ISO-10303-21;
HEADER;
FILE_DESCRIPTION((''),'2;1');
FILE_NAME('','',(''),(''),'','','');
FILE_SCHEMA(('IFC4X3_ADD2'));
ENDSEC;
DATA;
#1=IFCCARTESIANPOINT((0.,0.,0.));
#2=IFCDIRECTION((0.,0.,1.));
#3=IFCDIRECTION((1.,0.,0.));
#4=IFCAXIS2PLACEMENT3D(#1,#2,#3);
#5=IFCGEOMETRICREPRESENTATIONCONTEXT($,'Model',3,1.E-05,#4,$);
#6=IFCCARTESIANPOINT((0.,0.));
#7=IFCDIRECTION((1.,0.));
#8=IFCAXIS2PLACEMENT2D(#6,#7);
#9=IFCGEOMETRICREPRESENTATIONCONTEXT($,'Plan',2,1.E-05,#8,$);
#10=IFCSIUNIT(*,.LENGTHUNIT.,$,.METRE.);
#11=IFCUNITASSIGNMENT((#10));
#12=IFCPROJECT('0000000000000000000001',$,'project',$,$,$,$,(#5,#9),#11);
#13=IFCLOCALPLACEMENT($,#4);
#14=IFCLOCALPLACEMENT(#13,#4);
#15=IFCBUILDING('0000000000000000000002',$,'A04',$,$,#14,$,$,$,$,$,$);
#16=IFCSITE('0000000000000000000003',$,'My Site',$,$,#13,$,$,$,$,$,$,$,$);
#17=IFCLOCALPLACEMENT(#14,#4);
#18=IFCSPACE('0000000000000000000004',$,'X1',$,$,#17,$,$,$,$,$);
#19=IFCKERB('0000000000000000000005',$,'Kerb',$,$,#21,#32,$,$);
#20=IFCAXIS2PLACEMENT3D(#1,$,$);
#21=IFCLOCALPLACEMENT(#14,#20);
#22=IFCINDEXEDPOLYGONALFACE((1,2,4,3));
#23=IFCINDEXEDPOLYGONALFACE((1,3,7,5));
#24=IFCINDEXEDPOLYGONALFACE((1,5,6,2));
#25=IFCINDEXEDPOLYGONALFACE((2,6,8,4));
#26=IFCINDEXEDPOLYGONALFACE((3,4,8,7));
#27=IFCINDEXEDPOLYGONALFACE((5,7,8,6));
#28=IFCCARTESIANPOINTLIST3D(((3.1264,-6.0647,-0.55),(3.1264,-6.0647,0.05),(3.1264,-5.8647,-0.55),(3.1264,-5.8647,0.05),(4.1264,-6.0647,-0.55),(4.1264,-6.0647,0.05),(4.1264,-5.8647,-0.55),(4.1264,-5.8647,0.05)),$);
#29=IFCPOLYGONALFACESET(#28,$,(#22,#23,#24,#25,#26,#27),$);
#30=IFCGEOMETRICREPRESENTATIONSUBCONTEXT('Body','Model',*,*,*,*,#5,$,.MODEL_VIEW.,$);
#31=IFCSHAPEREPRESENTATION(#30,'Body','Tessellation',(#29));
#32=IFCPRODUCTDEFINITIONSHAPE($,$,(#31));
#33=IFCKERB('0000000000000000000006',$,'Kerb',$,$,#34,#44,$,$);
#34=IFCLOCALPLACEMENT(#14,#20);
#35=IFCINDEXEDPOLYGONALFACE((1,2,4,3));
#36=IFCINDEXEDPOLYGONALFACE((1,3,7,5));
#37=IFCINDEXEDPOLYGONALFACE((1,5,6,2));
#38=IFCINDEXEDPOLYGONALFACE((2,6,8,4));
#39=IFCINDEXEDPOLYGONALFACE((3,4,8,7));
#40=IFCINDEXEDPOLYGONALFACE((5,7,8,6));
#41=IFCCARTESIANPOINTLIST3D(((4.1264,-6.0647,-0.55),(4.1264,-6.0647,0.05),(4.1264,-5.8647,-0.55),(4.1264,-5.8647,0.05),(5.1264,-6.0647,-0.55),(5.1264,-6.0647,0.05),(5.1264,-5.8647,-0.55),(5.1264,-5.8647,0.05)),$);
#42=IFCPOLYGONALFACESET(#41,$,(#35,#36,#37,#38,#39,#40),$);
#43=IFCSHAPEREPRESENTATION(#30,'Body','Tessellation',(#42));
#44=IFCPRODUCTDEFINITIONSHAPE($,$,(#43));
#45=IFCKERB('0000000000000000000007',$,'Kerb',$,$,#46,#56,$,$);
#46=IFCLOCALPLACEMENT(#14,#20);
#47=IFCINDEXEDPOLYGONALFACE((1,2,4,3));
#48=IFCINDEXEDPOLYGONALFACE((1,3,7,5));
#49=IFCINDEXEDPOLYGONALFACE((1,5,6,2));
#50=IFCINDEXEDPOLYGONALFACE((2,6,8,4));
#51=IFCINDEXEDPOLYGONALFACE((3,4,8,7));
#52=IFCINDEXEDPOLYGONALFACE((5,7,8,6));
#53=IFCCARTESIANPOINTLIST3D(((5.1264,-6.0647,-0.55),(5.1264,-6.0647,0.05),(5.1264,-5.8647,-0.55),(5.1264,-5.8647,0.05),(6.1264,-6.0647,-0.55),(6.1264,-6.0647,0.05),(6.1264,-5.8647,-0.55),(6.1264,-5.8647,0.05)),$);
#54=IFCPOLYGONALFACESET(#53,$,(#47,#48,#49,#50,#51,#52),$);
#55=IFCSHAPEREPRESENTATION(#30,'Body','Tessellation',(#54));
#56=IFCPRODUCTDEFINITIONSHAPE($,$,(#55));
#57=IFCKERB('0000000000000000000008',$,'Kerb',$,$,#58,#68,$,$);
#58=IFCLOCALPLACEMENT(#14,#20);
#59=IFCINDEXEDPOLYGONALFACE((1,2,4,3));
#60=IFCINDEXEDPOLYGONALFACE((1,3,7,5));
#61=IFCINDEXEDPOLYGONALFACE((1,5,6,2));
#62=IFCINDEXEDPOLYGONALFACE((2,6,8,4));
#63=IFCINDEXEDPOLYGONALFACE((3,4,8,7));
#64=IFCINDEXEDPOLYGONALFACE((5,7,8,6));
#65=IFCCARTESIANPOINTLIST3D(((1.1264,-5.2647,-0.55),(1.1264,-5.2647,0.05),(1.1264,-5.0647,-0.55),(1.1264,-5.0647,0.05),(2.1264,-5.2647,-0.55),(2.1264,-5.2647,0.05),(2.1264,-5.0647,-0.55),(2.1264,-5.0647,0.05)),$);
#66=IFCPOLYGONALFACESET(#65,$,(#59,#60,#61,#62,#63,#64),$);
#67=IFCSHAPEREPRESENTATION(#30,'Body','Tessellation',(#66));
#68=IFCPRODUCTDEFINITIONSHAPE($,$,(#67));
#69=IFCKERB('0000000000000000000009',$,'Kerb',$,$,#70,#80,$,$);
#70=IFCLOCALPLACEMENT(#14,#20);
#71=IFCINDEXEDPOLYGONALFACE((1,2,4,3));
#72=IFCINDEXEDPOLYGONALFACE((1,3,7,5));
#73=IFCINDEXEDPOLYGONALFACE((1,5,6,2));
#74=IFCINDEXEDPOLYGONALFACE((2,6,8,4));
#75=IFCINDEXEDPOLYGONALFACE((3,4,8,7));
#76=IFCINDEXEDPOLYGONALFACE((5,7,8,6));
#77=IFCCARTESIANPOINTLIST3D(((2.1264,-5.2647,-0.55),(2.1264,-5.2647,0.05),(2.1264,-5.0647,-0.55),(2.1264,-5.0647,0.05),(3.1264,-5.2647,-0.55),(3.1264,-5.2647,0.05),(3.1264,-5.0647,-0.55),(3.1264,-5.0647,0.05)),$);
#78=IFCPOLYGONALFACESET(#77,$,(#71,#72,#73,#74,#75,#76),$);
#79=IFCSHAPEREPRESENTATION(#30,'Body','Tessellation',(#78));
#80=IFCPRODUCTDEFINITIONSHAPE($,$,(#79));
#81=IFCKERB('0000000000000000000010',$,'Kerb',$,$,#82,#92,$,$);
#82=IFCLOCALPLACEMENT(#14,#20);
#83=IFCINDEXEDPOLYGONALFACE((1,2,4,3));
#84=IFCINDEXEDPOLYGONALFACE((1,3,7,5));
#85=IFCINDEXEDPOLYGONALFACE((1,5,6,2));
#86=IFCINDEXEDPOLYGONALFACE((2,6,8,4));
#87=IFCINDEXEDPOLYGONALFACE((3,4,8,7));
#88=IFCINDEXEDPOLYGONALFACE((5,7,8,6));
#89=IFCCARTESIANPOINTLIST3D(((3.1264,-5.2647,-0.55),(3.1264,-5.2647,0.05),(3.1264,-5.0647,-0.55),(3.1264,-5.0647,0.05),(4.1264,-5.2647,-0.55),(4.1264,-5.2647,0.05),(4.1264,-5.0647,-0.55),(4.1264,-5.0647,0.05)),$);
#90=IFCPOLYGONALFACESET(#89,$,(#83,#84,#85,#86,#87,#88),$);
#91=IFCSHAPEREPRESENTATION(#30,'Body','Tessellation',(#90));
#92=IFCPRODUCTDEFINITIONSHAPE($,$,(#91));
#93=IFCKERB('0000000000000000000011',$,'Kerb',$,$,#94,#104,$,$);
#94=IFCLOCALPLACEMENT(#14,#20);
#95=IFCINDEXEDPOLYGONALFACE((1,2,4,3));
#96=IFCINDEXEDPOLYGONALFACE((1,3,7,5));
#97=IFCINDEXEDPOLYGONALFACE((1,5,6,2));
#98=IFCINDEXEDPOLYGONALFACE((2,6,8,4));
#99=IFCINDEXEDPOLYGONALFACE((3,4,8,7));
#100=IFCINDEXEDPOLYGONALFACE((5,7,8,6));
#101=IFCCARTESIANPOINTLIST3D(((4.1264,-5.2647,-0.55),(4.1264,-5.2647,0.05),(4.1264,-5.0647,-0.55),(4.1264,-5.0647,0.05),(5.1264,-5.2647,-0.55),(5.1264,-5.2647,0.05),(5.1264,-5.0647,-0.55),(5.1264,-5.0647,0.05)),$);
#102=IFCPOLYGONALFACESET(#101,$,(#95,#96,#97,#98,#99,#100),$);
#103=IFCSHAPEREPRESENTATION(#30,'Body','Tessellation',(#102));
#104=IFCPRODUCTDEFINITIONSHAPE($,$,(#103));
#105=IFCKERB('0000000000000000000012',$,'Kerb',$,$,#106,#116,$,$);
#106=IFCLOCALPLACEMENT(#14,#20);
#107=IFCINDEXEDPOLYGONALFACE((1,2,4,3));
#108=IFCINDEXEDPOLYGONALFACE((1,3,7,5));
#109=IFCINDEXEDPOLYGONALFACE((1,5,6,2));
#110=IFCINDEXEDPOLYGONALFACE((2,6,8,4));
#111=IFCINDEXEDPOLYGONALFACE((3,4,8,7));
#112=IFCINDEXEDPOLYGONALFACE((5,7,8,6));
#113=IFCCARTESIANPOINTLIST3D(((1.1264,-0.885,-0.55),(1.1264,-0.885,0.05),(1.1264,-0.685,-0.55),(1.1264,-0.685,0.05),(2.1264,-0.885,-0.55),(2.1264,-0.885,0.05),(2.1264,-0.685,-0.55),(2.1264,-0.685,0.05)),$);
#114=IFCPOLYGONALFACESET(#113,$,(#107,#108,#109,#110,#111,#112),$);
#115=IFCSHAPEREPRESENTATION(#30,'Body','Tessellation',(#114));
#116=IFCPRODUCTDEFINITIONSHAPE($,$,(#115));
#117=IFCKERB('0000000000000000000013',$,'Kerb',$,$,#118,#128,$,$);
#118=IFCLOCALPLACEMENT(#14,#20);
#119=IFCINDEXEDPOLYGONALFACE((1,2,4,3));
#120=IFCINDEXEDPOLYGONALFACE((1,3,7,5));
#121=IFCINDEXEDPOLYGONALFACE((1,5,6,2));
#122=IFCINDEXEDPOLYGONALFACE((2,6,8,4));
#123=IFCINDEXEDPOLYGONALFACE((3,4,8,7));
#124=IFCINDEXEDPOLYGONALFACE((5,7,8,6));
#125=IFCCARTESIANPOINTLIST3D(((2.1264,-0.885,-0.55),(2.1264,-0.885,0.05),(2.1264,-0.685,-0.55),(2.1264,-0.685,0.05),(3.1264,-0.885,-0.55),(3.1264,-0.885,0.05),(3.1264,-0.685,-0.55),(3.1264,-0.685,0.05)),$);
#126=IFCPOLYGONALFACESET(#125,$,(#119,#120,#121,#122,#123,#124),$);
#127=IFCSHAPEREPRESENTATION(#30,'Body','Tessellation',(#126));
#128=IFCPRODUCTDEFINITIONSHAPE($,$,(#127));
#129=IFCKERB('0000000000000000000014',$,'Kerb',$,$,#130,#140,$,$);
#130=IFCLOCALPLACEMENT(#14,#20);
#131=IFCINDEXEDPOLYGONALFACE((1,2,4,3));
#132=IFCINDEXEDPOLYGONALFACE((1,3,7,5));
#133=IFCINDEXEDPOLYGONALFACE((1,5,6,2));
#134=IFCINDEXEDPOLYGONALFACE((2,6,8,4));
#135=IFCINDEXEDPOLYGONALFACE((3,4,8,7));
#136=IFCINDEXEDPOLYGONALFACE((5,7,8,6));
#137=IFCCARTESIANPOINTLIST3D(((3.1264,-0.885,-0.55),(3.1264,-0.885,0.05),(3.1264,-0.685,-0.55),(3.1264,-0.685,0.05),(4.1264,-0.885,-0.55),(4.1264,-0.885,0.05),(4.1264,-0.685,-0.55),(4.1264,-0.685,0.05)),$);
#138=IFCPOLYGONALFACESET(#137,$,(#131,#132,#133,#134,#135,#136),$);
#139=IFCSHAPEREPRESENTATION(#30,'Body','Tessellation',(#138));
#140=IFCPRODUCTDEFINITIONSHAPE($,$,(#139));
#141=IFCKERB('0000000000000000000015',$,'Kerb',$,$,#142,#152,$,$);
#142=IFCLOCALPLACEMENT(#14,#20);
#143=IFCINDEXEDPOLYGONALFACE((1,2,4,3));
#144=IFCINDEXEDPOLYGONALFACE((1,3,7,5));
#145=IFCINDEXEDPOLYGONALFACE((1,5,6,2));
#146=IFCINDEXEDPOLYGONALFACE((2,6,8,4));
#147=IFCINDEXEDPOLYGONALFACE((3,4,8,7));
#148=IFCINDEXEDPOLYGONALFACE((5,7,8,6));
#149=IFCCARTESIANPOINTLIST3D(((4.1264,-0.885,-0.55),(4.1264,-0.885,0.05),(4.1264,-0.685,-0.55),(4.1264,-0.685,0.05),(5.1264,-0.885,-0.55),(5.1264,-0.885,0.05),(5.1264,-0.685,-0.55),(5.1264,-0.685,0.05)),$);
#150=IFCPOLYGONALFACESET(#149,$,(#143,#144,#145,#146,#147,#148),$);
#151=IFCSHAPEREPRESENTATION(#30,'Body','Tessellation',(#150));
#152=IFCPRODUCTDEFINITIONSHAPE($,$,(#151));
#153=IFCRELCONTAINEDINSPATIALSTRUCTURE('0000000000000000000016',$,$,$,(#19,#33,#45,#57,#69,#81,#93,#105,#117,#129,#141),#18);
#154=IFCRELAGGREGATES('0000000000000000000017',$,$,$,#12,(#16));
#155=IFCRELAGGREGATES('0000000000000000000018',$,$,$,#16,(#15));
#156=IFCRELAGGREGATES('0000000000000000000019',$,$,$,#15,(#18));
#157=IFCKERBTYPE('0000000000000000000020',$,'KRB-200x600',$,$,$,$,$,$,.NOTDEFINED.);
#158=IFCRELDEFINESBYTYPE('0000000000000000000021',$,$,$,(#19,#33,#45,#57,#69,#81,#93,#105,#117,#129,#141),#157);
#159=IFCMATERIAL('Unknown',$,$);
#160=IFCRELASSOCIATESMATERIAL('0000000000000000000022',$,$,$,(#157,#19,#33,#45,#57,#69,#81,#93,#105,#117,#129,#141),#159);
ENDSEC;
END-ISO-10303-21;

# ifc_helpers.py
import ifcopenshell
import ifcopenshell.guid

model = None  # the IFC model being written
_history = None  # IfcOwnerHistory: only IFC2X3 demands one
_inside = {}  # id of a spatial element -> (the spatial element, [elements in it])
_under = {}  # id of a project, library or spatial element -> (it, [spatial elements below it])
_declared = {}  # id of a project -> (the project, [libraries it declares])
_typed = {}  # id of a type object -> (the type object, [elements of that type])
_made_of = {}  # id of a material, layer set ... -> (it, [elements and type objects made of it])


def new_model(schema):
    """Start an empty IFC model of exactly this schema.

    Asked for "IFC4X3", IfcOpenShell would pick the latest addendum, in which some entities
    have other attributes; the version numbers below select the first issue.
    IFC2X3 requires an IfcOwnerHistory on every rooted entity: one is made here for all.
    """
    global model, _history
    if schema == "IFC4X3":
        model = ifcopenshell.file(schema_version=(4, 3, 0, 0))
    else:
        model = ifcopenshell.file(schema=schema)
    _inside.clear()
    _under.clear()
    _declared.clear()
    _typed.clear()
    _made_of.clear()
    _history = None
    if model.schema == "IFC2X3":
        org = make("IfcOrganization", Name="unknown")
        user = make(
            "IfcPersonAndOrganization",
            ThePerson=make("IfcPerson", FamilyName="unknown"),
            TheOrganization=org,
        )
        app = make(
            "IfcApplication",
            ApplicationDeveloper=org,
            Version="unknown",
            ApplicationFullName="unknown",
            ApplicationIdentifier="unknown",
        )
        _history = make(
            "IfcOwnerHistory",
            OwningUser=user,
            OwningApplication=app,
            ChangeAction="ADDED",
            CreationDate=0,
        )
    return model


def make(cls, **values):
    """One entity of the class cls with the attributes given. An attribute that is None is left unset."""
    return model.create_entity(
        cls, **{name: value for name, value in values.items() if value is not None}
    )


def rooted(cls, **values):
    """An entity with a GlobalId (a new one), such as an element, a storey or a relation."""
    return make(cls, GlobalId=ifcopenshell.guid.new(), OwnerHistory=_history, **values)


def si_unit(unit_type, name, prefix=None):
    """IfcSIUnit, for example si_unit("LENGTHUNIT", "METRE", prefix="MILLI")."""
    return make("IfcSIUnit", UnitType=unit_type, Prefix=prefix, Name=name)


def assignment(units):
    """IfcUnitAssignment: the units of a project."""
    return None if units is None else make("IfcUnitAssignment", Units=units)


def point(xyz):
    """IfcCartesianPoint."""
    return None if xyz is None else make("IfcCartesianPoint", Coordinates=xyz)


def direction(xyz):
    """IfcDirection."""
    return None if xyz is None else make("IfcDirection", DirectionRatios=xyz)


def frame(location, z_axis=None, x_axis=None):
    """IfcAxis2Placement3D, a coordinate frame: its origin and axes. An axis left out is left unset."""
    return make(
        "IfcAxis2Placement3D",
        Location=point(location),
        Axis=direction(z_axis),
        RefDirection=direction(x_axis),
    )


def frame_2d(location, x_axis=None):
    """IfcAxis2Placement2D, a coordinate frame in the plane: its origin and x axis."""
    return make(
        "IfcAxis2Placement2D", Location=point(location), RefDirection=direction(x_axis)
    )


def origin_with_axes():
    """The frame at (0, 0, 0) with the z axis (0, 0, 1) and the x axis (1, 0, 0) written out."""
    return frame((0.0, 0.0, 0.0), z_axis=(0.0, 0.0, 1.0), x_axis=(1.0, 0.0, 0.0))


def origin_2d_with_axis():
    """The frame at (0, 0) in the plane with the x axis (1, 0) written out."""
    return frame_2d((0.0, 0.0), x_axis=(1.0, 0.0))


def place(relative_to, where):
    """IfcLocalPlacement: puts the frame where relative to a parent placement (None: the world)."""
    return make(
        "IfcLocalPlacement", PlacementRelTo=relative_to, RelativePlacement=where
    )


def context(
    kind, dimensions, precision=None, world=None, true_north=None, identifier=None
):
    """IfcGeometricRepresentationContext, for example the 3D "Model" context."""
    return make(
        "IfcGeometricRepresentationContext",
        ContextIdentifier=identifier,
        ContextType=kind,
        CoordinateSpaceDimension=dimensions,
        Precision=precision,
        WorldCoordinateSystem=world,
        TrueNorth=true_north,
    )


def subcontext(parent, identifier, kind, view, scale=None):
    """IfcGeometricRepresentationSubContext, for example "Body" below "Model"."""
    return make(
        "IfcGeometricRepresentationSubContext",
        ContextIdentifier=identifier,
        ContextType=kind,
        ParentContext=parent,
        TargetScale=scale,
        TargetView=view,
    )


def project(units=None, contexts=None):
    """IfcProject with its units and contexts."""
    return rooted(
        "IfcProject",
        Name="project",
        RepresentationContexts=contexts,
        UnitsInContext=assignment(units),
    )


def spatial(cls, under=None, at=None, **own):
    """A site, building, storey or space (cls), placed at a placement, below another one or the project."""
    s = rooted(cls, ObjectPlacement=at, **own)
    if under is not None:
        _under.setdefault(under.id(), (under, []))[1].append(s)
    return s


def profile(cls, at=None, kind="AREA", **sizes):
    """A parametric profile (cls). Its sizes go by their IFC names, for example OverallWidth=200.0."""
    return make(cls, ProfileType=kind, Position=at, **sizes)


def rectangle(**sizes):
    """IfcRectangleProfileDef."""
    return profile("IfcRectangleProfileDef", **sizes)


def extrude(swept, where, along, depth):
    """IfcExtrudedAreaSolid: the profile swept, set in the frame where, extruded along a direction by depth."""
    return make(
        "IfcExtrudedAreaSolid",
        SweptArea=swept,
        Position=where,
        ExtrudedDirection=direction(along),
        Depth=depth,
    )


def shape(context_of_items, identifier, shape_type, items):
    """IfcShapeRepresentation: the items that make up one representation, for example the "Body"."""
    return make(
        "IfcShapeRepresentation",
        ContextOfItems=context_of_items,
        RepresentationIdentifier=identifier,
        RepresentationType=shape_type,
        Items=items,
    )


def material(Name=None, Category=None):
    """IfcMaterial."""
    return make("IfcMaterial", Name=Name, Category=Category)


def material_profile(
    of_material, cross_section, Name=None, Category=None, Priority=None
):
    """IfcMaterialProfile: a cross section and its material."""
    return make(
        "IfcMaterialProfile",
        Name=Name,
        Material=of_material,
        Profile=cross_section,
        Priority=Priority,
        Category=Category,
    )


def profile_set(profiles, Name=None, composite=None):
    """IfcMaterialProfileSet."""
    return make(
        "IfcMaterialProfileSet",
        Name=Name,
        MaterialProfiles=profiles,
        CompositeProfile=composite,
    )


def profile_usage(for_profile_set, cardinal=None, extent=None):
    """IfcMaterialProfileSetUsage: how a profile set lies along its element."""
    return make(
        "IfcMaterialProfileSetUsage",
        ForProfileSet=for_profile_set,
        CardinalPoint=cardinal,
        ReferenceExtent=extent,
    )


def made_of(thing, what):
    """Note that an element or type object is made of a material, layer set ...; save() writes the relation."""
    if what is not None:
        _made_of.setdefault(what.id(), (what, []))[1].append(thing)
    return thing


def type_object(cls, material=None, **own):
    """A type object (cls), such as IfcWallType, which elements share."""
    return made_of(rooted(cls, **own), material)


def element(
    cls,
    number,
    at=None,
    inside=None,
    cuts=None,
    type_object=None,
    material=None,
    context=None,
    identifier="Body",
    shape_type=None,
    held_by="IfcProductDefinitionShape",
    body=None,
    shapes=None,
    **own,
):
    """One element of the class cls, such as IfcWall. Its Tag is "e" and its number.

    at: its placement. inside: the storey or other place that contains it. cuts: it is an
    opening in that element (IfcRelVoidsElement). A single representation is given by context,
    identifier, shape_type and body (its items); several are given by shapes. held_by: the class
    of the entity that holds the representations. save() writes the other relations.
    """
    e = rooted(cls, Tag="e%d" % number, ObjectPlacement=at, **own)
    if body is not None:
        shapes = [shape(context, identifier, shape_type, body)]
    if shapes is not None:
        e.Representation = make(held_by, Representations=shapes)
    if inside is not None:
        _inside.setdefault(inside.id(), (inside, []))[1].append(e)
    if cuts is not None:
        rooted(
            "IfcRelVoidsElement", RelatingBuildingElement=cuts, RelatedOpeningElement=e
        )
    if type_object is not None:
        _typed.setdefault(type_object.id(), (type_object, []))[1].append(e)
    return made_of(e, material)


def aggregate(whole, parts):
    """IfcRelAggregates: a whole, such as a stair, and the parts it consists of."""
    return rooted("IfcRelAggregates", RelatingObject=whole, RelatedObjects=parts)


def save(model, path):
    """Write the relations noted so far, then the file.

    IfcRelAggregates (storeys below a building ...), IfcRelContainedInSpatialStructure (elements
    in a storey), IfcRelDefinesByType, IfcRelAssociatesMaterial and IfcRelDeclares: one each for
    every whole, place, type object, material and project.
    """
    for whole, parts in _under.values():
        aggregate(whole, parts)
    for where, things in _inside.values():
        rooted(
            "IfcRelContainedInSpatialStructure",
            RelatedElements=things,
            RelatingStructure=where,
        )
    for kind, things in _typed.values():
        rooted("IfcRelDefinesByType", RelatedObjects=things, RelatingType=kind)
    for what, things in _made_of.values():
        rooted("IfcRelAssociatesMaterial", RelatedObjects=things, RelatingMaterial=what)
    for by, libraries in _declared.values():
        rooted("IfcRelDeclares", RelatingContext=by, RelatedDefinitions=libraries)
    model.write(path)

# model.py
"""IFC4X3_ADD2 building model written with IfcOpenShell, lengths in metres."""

from ifc_helpers import new_model, si_unit, frame, origin_with_axes, origin_2d_with_axis, place, context, subcontext, project, spatial, rectangle, extrude, material, material_profile, profile_set, profile_usage, type_object, element, save


model = new_model("IFC4X3_ADD2")

# Units and contexts
model_context = context("Model", 3, precision=1e-05, world=origin_with_axes())
plan_context = context("Plan", 2, precision=1e-05, world=origin_2d_with_axis())
body_context = subcontext(model_context, "Body", "Model", "MODEL_VIEW")
ifc_project = project(units=[si_unit("LENGTHUNIT", "METRE")], contexts=[model_context, plan_context])

# Site, building, space
site_placement = place(None, origin_with_axes())
site = spatial("IfcSite", under=ifc_project, at=site_placement, Name="My Site")
building_placement = place(site_placement, origin_with_axes())
building = spatial("IfcBuilding", under=site, at=building_placement, Name="A04")
space_placement = place(building_placement, origin_with_axes())
space = spatial("IfcSpace", under=building, at=space_placement, Name="X1")

# Shared definitions
ifc_material = material(Name="Unknown")

# Kerbs
ifc_material_profile = material_profile(ifc_material, rectangle(XDim=0.2, YDim=0.6))
ifc_profile_set = profile_set([ifc_material_profile])
kerb_type = type_object("IfcKerbType", Name="KRB-200x600", PredefinedType="NOTDEFINED", material=ifc_profile_set)
ifc_profile_usage_1 = profile_usage(ifc_profile_set, cardinal=2)
kerb_1_placement = place(space_placement, frame((3.1264, -5.9647, -0.55), z_axis=(1.0, 0.0, 0.0), x_axis=(0.0, 1.0, 0.0)))
element("IfcKerb", 1, at=kerb_1_placement, inside=space, type_object=kerb_type, material=ifc_profile_usage_1, Name="Kerb", context=body_context, shape_type="SweptSolid", body=[
    extrude(rectangle(XDim=0.2, YDim=0.6), frame((0.0, 0.3, 0.0), z_axis=(0.0, 0.0, 1.0), x_axis=(1.0, 0.0, 0.0)), (0.0, 0.0, 1.0), 1.0),
])
ifc_profile_usage_2 = profile_usage(ifc_profile_set, cardinal=2)
kerb_2_placement = place(space_placement, frame((4.1264, -5.9647, -0.55), z_axis=(1.0, 0.0, 0.0), x_axis=(0.0, 1.0, 0.0)))
element("IfcKerb", 2, at=kerb_2_placement, inside=space, type_object=kerb_type, material=ifc_profile_usage_2, Name="Kerb", context=body_context, shape_type="SweptSolid", body=[
    extrude(rectangle(XDim=0.2, YDim=0.6), frame((0.0, 0.3, 0.0), z_axis=(0.0, 0.0, 1.0), x_axis=(1.0, 0.0, 0.0)), (0.0, 0.0, 1.0), 1.0),
])
ifc_profile_usage_3 = profile_usage(ifc_profile_set, cardinal=2)
kerb_3_placement = place(space_placement, frame((5.1264, -5.9647, -0.55), z_axis=(1.0, 0.0, 0.0), x_axis=(0.0, 1.0, 0.0)))
element("IfcKerb", 3, at=kerb_3_placement, inside=space, type_object=kerb_type, material=ifc_profile_usage_3, Name="Kerb", context=body_context, shape_type="SweptSolid", body=[
    extrude(rectangle(XDim=0.2, YDim=0.6), frame((0.0, 0.3, 0.0), z_axis=(0.0, 0.0, 1.0), x_axis=(1.0, 0.0, 0.0)), (0.0, 0.0, 1.0), 1.0),
])
ifc_profile_usage_4 = profile_usage(ifc_profile_set, cardinal=2)
kerb_4_placement = place(space_placement, frame((1.1264, -5.1647, -0.55), z_axis=(1.0, 0.0, 0.0), x_axis=(0.0, 1.0, 0.0)))
element("IfcKerb", 4, at=kerb_4_placement, inside=space, type_object=kerb_type, material=ifc_profile_usage_4, Name="Kerb", context=body_context, shape_type="SweptSolid", body=[
    extrude(rectangle(XDim=0.2, YDim=0.6), frame((0.0, 0.3, 0.0), z_axis=(0.0, 0.0, 1.0), x_axis=(1.0, 0.0, 0.0)), (0.0, 0.0, 1.0), 1.0),
])
ifc_profile_usage_5 = profile_usage(ifc_profile_set, cardinal=2)
kerb_5_placement = place(space_placement, frame((2.1264, -5.1647, -0.55), z_axis=(1.0, 0.0, 0.0), x_axis=(0.0, 1.0, 0.0)))
element("IfcKerb", 5, at=kerb_5_placement, inside=space, type_object=kerb_type, material=ifc_profile_usage_5, Name="Kerb", context=body_context, shape_type="SweptSolid", body=[
    extrude(rectangle(XDim=0.2, YDim=0.6), frame((0.0, 0.3, 0.0), z_axis=(0.0, 0.0, 1.0), x_axis=(1.0, 0.0, 0.0)), (0.0, 0.0, 1.0), 1.0),
])
ifc_profile_usage_6 = profile_usage(ifc_profile_set, cardinal=2)
kerb_6_placement = place(space_placement, frame((3.1264, -5.1647, -0.55), z_axis=(1.0, 0.0, 0.0), x_axis=(0.0, 1.0, 0.0)))
element("IfcKerb", 6, at=kerb_6_placement, inside=space, type_object=kerb_type, material=ifc_profile_usage_6, Name="Kerb", context=body_context, shape_type="SweptSolid", body=[
    extrude(rectangle(XDim=0.2, YDim=0.6), frame((0.0, 0.3, 0.0), z_axis=(0.0, 0.0, 1.0), x_axis=(1.0, 0.0, 0.0)), (0.0, 0.0, 1.0), 1.0),
])
ifc_profile_usage_7 = profile_usage(ifc_profile_set, cardinal=2)
kerb_7_placement = place(space_placement, frame((4.1264, -5.1647, -0.55), z_axis=(1.0, 0.0, 0.0), x_axis=(0.0, 1.0, 0.0)))
element("IfcKerb", 7, at=kerb_7_placement, inside=space, type_object=kerb_type, material=ifc_profile_usage_7, Name="Kerb", context=body_context, shape_type="SweptSolid", body=[
    extrude(rectangle(XDim=0.2, YDim=0.6), frame((0.0, 0.3, 0.0), z_axis=(0.0, 0.0, 1.0), x_axis=(1.0, 0.0, 0.0)), (0.0, 0.0, 1.0), 1.0),
])
ifc_profile_usage_8 = profile_usage(ifc_profile_set, cardinal=2)
kerb_8_placement = place(space_placement, frame((1.1264, -0.785, -0.55), z_axis=(1.0, 0.0, 0.0), x_axis=(0.0, 1.0, 0.0)))
element("IfcKerb", 8, at=kerb_8_placement, inside=space, type_object=kerb_type, material=ifc_profile_usage_8, Name="Kerb", context=body_context, shape_type="SweptSolid", body=[
    extrude(rectangle(XDim=0.2, YDim=0.6), frame((0.0, 0.3, 0.0), z_axis=(0.0, 0.0, 1.0), x_axis=(1.0, 0.0, 0.0)), (0.0, 0.0, 1.0), 1.0),
])
ifc_profile_usage_9 = profile_usage(ifc_profile_set, cardinal=2)
kerb_9_placement = place(space_placement, frame((2.1264, -0.785, -0.55), z_axis=(1.0, 0.0, 0.0), x_axis=(0.0, 1.0, 0.0)))
element("IfcKerb", 9, at=kerb_9_placement, inside=space, type_object=kerb_type, material=ifc_profile_usage_9, Name="Kerb", context=body_context, shape_type="SweptSolid", body=[
    extrude(rectangle(XDim=0.2, YDim=0.6), frame((0.0, 0.3, 0.0), z_axis=(0.0, 0.0, 1.0), x_axis=(1.0, 0.0, 0.0)), (0.0, 0.0, 1.0), 1.0),
])
ifc_profile_usage_10 = profile_usage(ifc_profile_set, cardinal=2)
kerb_10_placement = place(space_placement, frame((3.1264, -0.785, -0.55), z_axis=(1.0, 0.0, 0.0), x_axis=(0.0, 1.0, 0.0)))
element("IfcKerb", 10, at=kerb_10_placement, inside=space, type_object=kerb_type, material=ifc_profile_usage_10, Name="Kerb", context=body_context, shape_type="SweptSolid", body=[
    extrude(rectangle(XDim=0.2, YDim=0.6), frame((0.0, 0.3, 0.0), z_axis=(0.0, 0.0, 1.0), x_axis=(1.0, 0.0, 0.0)), (0.0, 0.0, 1.0), 1.0),
])
ifc_profile_usage_11 = profile_usage(ifc_profile_set, cardinal=2)
kerb_11_placement = place(space_placement, frame((4.1264, -0.785, -0.55), z_axis=(1.0, 0.0, 0.0), x_axis=(0.0, 1.0, 0.0)))
element("IfcKerb", 11, at=kerb_11_placement, inside=space, type_object=kerb_type, material=ifc_profile_usage_11, Name="Kerb", context=body_context, shape_type="SweptSolid", body=[
    extrude(rectangle(XDim=0.2, YDim=0.6), frame((0.0, 0.3, 0.0), z_axis=(0.0, 0.0, 1.0), x_axis=(1.0, 0.0, 0.0)), (0.0, 0.0, 1.0), 1.0),
])

save(model, "model.ifc")
